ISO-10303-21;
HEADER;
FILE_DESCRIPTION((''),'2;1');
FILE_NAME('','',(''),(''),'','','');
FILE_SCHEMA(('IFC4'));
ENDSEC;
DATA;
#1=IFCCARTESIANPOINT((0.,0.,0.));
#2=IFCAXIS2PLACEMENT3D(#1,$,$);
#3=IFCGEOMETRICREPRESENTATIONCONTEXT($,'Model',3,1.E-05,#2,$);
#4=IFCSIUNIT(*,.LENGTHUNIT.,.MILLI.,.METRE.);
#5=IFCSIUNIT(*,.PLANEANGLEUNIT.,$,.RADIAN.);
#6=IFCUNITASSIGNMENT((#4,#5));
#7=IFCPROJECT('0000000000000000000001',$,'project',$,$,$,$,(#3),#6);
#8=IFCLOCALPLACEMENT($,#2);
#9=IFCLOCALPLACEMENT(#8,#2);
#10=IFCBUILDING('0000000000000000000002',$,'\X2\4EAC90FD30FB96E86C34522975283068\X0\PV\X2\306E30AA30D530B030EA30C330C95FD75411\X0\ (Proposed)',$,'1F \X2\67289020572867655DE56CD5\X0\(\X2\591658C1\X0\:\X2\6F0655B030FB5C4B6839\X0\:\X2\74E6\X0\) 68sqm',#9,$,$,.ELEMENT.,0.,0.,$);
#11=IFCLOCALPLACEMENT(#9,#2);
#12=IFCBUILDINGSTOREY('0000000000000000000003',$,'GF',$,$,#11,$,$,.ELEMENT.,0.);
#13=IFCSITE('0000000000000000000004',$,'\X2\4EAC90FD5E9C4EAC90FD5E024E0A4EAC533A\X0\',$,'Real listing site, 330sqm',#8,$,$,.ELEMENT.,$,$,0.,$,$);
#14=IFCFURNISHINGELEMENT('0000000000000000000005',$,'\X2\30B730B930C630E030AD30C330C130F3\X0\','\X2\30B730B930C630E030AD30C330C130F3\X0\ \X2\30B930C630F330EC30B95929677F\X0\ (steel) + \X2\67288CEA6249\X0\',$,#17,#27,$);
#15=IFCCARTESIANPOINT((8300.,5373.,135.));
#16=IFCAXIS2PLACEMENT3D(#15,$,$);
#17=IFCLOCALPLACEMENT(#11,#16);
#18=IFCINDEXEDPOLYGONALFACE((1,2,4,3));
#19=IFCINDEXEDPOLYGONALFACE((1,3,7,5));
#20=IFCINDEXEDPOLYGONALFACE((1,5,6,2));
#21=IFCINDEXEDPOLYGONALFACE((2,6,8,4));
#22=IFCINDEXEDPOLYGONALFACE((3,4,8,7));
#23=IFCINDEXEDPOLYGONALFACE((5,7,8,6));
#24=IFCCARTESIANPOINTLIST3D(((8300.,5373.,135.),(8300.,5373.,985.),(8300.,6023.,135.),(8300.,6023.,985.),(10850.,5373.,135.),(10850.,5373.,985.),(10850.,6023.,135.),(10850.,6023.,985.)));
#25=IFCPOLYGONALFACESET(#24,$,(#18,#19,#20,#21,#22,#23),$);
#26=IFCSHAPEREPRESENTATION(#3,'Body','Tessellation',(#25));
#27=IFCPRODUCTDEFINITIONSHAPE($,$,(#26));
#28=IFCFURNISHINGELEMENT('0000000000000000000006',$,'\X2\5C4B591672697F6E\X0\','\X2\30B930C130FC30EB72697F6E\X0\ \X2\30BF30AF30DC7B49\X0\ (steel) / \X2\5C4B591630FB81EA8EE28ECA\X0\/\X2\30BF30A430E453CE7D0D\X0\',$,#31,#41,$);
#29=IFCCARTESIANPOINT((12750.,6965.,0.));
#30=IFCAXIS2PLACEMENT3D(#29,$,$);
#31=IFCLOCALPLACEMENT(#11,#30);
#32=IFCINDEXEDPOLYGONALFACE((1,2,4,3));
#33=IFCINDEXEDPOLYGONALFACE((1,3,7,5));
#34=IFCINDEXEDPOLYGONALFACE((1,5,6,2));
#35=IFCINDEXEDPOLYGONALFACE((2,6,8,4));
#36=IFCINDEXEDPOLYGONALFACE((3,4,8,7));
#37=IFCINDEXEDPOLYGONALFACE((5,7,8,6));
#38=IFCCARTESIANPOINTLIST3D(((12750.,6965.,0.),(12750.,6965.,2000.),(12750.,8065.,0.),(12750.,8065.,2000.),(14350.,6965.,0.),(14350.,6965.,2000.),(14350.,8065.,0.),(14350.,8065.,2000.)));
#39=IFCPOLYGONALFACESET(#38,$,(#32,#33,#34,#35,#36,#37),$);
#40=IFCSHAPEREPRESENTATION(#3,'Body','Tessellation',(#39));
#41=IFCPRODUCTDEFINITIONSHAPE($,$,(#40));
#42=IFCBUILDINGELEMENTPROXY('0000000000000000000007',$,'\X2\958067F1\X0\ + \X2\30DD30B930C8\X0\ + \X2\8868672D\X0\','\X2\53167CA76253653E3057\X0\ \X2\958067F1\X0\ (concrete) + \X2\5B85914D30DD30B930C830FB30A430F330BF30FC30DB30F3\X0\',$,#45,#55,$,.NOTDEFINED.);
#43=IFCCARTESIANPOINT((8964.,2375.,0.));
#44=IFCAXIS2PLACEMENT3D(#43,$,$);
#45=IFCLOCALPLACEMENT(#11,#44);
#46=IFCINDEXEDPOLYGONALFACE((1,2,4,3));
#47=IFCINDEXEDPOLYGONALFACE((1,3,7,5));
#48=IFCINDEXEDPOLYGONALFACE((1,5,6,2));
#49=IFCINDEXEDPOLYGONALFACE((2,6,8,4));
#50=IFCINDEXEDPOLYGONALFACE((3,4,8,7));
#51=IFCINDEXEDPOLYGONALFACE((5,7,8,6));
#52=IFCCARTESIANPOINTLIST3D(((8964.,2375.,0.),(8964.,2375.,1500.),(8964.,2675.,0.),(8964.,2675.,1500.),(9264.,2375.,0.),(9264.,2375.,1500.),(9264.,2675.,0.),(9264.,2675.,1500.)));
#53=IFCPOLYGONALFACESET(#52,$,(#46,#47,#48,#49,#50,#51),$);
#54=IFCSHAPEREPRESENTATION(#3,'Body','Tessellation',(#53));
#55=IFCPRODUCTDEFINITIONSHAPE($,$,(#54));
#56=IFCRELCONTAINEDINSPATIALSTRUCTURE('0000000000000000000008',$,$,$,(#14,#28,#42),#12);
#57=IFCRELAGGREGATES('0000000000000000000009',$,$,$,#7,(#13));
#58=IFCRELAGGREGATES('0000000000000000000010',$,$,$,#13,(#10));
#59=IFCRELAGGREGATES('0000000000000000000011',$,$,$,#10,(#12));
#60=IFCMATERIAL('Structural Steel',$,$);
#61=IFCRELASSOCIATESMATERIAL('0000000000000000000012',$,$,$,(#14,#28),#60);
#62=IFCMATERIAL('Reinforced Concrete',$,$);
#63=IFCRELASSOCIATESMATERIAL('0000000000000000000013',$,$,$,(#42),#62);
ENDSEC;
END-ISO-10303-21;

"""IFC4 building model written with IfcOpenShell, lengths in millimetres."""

from ifc_helpers import new_model, si_unit, frame, frame_2d, origin, place, context, project, spatial, rectangle, extrude, material, element, save


model = new_model("IFC4")

# Units and contexts
model_context = context("Model", 3, precision=1e-05, world=origin())
ifc_project = project(units=[si_unit("LENGTHUNIT", "METRE", prefix="MILLI"), si_unit("PLANEANGLEUNIT", "RADIAN")], contexts=[model_context])

# Site, building, storey
site_placement = place(None, origin())
site = spatial("IfcSite", under=ifc_project, at=site_placement, Name="京都府京都市上京区", ObjectType="Real listing site, 330sqm", CompositionType="ELEMENT", RefElevation=0.0)
building_placement = place(site_placement, origin())
building = spatial("IfcBuilding", under=site, at=building_placement, Name="京都・雨水利用とPVのオフグリッド志向 (Proposed)", ObjectType="1F 木造在来工法(外壁:漆喰・屋根:瓦) 68sqm", CompositionType="ELEMENT", ElevationOfRefHeight=0.0, ElevationOfTerrain=0.0)
storey_placement = place(building_placement, origin())
storey = spatial("IfcBuildingStorey", under=building, at=storey_placement, Name="GF", CompositionType="ELEMENT", Elevation=0.0)

# Shared definitions
ifc_material_1 = material(Name="Reinforced Concrete")

# Shared definitions
ifc_material_2 = material(Name="Structural Steel")

# Furnishing elements
furnishing_1_placement = place(storey_placement, frame((8300.0, 5373.0, 135.0)))
element("IfcFurnishingElement", 1, at=furnishing_1_placement, inside=storey, material=ifc_material_2, Name="システムキッチン", Description="システムキッチン ステンレス天板 (steel) + 木質扉", context=model_context, shape_type="SweptSolid", body=[
    extrude(rectangle(XDim=2550.0, YDim=650.0, at=frame_2d((1275.0, 325.0))), frame((8300.0, 5373.0, 135.0)), (0.0, 0.0, 1.0), 850.0),
])
furnishing_2_placement = place(storey_placement, frame((12750.0, 6965.0, 0.0)))
element("IfcFurnishingElement", 2, at=furnishing_2_placement, inside=storey, material=ifc_material_2, Name="屋外物置", Description="スチール物置 タクボ等 (steel) / 屋外・自転車/タイヤ収納", context=model_context, shape_type="SweptSolid", body=[
    extrude(rectangle(XDim=1600.0, YDim=1100.0, at=frame_2d((800.0, 550.0))), frame((12750.0, 6965.0, 0.0)), (0.0, 0.0, 1.0), 2000.0),
])

# Building element proxy
proxy_placement = place(storey_placement, frame((8964.0, 2375.0, 0.0)))
element("IfcBuildingElementProxy", 3, at=proxy_placement, inside=storey, material=ifc_material_1, Name="門柱 + ポスト + 表札", Description="化粧打放し 門柱 (concrete) + 宅配ポスト・インターホン", PredefinedType="NOTDEFINED", context=model_context, shape_type="SweptSolid", body=[
    extrude(rectangle(XDim=300.0, YDim=300.0, at=frame_2d((150.0, 150.0))), frame((8964.0, 2375.0, 0.0)), (0.0, 0.0, 1.0), 1500.0),
])

save(model, "model.ifc")
